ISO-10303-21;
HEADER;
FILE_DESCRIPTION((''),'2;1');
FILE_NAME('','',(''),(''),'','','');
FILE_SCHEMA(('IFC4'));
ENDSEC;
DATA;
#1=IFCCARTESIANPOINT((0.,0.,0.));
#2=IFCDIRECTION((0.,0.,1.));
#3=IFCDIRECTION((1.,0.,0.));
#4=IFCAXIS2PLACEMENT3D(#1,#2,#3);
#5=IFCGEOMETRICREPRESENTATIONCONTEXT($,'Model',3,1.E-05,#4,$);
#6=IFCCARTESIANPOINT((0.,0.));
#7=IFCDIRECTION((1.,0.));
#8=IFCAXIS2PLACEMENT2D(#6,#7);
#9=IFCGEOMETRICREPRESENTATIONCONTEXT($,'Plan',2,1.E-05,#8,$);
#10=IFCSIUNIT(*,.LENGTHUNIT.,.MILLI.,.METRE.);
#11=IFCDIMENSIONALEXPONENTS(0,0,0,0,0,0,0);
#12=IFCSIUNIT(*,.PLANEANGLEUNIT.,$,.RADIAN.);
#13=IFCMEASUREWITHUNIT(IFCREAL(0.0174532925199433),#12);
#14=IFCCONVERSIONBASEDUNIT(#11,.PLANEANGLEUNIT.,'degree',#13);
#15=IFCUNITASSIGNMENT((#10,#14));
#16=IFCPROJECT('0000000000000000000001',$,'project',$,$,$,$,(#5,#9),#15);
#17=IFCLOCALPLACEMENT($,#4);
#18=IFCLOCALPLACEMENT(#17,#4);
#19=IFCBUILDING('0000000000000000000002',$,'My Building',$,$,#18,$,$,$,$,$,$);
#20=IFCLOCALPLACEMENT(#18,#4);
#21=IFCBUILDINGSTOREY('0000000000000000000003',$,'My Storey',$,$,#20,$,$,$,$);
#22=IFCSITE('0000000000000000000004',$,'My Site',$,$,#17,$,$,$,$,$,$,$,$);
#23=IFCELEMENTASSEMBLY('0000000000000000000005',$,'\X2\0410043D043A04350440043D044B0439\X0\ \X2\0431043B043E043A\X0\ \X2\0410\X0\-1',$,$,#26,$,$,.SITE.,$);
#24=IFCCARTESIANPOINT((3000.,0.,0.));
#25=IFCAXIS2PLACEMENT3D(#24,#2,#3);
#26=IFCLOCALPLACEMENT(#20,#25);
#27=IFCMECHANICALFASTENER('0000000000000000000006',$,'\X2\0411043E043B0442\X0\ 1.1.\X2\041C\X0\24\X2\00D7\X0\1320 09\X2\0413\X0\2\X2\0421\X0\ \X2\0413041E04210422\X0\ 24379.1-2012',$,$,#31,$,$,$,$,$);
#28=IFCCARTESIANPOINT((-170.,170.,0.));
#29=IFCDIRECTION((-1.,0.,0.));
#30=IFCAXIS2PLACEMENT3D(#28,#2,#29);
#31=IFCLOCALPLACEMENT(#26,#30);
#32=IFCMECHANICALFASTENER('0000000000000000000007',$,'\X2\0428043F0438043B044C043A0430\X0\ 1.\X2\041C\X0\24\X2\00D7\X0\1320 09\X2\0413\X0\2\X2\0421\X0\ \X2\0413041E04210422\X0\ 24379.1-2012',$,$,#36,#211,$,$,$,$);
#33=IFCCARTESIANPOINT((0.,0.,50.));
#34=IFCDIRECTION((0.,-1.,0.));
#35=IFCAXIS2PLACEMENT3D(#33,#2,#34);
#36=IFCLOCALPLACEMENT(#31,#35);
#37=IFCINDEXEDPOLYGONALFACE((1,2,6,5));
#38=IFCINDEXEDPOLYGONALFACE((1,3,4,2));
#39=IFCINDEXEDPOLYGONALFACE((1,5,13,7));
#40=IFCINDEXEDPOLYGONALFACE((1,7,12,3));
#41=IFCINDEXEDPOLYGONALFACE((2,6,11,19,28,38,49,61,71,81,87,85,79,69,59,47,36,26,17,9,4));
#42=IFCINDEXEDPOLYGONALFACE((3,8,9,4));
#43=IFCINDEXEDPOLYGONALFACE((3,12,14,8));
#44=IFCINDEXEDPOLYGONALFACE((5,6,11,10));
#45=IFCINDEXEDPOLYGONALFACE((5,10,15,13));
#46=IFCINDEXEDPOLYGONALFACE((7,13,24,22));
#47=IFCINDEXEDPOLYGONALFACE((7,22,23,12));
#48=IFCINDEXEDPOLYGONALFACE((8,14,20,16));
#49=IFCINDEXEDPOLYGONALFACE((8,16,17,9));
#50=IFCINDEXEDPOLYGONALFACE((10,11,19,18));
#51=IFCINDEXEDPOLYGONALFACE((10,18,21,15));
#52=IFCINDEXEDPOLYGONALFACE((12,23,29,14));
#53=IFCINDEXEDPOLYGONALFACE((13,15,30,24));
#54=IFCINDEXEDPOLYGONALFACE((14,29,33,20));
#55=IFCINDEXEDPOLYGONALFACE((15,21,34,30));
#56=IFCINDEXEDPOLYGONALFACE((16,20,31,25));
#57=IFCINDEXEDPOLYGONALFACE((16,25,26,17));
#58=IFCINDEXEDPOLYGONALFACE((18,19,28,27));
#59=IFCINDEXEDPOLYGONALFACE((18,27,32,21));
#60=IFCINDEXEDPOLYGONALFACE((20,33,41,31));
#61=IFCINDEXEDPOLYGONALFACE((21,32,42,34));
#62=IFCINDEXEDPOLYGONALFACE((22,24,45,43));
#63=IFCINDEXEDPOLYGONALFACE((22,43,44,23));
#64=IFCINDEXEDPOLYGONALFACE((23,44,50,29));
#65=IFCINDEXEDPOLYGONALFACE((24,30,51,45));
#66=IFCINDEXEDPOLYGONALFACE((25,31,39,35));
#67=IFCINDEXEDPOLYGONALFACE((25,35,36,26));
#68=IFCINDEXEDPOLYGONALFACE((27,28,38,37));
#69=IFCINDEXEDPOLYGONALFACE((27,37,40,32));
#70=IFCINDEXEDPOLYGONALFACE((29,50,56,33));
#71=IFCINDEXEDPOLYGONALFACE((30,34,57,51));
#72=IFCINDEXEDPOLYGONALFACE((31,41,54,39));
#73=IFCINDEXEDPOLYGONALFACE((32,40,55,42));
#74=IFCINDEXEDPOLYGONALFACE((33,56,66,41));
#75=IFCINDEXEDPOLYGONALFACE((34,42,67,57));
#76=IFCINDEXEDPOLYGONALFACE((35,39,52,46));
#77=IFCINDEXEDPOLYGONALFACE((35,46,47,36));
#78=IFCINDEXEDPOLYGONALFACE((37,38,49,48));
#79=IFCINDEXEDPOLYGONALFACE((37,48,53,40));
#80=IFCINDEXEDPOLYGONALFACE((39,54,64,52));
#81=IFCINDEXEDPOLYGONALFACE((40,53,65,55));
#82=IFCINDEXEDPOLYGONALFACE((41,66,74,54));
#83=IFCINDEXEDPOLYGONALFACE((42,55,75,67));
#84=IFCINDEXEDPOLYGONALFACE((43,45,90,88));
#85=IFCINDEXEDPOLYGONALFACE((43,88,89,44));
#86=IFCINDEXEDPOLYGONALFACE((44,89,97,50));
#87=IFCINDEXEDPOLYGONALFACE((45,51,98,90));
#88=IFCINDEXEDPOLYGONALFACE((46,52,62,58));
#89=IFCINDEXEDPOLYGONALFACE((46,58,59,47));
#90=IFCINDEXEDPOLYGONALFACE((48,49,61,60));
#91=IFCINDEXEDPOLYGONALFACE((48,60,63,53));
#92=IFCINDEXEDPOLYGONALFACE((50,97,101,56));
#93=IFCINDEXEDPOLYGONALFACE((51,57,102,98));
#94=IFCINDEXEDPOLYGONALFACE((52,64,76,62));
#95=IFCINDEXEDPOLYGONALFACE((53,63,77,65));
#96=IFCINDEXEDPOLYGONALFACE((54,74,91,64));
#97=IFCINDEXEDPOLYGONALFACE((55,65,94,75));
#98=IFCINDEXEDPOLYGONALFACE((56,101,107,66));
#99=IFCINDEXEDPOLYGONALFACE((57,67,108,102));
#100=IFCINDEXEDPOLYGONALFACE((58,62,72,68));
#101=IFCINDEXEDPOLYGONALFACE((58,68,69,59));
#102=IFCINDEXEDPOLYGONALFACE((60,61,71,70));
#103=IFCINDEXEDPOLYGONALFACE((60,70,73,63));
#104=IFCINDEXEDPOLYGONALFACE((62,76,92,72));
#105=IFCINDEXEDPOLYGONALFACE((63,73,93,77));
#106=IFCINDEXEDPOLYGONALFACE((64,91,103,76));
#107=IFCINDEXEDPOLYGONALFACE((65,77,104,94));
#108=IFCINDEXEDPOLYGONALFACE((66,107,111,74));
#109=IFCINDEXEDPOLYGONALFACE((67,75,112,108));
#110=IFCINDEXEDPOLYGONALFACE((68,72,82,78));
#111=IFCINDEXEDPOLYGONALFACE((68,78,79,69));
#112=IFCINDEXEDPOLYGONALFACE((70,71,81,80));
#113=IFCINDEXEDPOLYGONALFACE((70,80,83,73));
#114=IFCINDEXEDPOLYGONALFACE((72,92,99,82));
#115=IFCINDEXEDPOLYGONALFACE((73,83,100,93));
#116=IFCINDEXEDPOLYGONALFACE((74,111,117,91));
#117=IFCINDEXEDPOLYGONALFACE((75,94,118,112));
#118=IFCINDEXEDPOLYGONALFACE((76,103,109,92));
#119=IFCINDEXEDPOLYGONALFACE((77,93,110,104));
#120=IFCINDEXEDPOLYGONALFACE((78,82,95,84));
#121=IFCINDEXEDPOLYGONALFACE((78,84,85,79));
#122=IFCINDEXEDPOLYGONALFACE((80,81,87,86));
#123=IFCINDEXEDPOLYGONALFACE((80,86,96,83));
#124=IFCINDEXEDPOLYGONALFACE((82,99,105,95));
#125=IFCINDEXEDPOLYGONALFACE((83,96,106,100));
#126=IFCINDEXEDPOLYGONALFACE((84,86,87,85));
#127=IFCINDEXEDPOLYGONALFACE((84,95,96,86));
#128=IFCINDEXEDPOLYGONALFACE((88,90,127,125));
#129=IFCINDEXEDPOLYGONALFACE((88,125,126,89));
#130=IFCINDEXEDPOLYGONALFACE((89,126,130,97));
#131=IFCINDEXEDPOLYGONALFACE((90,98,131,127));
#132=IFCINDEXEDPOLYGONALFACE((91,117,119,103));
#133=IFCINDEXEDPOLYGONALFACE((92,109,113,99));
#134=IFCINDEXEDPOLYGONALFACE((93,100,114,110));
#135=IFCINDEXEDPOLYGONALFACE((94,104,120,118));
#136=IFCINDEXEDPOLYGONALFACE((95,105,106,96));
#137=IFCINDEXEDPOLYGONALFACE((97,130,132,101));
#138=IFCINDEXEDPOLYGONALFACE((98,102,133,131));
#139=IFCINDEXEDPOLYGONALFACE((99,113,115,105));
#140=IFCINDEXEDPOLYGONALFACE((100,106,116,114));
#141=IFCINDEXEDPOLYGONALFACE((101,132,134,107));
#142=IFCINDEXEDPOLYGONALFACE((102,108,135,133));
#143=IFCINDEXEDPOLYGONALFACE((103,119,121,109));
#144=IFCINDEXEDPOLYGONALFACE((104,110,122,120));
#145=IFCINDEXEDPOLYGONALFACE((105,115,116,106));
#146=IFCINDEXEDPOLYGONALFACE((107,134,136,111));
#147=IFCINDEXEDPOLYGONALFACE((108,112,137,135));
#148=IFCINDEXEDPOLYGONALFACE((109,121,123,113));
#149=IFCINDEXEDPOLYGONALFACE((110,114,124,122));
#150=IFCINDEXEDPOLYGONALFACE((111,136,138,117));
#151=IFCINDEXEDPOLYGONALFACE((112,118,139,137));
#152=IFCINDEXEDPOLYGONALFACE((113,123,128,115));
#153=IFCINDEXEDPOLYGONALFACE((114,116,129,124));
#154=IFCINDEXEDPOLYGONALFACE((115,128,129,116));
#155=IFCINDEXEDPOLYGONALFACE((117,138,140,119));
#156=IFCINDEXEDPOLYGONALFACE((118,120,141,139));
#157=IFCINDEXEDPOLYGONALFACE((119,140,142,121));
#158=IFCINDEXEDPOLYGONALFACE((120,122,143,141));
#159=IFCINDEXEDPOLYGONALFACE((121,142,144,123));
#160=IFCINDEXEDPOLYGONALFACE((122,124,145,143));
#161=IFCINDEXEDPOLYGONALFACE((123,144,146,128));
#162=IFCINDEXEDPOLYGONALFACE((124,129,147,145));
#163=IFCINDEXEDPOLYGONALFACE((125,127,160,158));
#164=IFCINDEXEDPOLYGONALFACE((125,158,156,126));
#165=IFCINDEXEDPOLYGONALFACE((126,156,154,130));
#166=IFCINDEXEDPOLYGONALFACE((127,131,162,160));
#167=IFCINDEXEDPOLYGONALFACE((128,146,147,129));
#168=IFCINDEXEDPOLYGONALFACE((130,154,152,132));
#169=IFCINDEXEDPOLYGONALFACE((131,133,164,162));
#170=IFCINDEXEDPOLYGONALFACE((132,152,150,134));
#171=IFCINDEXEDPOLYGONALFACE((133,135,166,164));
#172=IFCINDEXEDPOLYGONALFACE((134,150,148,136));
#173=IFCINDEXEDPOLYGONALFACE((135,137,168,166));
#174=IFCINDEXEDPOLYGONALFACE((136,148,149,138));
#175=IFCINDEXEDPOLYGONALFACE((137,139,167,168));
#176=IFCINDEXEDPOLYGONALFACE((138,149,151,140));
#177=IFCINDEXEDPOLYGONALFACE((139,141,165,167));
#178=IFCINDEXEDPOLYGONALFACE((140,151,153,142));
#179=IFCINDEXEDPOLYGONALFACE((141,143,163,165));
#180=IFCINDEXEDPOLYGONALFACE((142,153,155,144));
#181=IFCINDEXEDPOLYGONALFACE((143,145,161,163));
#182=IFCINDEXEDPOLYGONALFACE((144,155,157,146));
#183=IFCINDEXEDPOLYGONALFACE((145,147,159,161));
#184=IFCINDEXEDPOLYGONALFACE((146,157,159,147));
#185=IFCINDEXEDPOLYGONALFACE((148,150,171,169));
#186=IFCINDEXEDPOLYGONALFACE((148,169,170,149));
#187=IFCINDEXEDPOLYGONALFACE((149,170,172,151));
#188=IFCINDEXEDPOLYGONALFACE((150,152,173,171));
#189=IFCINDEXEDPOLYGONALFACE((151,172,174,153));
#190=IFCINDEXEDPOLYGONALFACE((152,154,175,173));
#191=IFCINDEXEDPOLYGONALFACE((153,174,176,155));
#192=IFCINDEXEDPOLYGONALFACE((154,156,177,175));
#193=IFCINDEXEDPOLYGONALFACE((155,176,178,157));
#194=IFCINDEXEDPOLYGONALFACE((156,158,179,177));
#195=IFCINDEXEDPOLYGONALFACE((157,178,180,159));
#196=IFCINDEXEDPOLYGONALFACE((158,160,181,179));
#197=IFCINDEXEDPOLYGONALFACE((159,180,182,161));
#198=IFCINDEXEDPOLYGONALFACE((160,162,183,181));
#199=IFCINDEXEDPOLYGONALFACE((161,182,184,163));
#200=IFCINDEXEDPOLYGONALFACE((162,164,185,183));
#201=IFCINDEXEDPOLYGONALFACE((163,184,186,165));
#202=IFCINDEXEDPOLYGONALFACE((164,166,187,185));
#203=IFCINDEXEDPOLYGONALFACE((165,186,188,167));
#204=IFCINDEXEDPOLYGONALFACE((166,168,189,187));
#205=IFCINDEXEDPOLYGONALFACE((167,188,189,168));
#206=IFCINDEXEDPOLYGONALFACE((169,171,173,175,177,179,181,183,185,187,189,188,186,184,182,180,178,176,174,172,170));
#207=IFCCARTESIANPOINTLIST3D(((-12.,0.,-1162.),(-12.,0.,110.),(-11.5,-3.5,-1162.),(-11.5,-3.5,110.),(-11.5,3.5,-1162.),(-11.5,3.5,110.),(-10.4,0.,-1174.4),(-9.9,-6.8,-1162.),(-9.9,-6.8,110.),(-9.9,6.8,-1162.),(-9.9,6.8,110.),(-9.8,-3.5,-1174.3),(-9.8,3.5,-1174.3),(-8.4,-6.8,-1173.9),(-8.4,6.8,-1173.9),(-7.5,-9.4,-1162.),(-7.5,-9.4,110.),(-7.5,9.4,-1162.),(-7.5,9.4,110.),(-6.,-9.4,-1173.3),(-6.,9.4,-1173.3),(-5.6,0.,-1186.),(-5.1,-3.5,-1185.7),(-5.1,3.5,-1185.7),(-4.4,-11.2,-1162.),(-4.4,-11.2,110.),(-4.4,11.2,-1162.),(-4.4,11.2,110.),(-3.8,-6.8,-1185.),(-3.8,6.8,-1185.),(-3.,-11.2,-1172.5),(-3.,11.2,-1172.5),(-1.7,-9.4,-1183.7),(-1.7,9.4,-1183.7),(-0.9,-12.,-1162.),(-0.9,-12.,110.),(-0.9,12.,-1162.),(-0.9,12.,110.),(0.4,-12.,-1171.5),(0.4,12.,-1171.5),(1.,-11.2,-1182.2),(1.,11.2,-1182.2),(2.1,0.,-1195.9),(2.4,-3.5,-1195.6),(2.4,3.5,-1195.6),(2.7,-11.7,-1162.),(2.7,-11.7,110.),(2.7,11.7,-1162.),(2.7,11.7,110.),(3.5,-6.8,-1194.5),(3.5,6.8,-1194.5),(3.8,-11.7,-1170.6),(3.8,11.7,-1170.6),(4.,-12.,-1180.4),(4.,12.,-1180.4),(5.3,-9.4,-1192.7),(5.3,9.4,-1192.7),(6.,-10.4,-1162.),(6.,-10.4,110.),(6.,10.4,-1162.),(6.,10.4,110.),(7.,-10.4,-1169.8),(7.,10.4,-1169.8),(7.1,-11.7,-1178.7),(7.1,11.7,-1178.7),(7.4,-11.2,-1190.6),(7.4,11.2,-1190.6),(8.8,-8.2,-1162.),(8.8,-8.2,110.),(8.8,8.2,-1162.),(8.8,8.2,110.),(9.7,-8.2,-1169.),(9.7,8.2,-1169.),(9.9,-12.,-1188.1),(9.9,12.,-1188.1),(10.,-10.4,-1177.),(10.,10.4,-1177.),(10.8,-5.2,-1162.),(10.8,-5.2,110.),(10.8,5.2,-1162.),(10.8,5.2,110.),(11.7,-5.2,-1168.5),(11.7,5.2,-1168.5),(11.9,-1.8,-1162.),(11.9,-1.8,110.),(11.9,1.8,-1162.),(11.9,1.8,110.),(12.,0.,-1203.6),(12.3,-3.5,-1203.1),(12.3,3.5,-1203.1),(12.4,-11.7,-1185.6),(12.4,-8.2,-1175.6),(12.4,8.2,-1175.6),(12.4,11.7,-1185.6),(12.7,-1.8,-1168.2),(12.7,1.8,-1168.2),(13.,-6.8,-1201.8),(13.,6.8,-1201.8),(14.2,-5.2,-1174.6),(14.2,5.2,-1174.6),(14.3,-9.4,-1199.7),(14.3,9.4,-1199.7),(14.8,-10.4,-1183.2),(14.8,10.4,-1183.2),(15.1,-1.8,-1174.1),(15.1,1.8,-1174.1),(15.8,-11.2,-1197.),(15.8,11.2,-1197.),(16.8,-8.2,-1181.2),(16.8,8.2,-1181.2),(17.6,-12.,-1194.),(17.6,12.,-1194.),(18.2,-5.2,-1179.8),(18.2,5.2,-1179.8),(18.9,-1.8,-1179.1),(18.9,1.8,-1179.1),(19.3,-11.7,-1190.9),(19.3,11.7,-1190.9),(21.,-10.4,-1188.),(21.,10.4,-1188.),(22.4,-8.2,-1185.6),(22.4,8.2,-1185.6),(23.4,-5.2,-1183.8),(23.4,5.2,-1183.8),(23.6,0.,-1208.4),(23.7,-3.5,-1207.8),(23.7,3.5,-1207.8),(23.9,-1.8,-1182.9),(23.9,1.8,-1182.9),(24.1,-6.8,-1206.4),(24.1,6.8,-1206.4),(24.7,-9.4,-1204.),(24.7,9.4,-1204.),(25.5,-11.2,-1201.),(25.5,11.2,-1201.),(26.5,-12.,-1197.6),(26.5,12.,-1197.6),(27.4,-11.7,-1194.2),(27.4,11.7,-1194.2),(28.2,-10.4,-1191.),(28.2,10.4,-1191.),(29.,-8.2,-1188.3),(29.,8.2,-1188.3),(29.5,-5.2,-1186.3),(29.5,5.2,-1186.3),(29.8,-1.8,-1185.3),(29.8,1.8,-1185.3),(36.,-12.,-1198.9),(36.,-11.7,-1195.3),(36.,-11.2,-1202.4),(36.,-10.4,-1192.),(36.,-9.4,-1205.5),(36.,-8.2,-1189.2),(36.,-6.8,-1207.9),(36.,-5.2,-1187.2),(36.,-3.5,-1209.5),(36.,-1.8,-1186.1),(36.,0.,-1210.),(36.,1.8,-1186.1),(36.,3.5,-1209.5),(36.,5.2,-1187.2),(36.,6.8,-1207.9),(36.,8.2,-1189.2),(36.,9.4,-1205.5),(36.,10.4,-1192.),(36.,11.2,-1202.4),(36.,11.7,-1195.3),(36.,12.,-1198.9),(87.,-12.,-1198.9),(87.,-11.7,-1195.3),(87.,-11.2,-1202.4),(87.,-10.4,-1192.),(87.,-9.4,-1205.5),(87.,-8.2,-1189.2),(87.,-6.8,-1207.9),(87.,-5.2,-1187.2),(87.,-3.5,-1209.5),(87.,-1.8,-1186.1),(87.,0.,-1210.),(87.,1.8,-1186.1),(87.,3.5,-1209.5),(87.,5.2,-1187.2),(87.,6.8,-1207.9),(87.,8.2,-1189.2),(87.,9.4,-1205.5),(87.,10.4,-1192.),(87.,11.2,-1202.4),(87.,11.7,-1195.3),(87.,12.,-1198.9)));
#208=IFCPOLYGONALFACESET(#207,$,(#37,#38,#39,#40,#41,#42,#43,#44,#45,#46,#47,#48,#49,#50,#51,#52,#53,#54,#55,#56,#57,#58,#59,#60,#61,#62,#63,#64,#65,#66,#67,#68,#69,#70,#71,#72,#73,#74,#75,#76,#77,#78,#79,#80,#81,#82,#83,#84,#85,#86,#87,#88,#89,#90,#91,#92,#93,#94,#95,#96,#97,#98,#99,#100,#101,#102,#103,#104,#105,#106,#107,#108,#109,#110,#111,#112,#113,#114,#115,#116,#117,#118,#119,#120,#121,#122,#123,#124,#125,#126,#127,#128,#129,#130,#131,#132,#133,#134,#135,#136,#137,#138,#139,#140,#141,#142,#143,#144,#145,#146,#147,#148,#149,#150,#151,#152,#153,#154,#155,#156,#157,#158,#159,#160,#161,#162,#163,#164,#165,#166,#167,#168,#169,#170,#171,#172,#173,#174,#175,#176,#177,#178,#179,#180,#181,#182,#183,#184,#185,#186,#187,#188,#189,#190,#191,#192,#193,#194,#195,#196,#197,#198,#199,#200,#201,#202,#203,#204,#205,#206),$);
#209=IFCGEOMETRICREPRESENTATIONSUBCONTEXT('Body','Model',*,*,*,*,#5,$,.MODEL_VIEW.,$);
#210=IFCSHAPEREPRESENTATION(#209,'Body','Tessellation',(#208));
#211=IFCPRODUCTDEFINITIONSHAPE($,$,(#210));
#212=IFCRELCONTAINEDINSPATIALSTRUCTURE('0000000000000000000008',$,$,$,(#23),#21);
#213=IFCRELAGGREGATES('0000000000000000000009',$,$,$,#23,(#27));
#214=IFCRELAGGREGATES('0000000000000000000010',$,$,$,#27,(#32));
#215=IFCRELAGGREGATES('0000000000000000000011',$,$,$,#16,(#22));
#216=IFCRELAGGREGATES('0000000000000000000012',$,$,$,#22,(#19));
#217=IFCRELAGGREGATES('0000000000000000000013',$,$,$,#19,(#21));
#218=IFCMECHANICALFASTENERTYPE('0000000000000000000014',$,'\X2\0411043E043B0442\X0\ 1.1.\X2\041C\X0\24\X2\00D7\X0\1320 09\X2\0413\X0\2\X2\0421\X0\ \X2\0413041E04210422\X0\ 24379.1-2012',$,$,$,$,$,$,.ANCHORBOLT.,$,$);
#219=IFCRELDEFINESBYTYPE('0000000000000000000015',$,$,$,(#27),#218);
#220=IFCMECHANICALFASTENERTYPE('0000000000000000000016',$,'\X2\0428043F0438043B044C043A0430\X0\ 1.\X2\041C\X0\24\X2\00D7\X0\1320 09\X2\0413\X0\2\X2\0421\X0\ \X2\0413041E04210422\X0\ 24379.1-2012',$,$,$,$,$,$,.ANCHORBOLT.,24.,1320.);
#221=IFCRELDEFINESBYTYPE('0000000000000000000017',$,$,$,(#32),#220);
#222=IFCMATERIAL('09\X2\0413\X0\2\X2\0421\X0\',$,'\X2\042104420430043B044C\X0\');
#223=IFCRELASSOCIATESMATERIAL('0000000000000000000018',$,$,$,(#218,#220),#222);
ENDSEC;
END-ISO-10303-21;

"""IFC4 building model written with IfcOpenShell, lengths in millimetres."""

from ifc_helpers import new_model, entity, si_unit, converted_unit, frame, origin_with_axes, origin_2d_with_axis, place, context, subcontext, project, spatial, source, transform, mapped, material, type_object, type_shapes, element, aggregate, save


model = new_model("IFC4")

# Units and contexts
model_context = context("Model", 3, precision=1e-05, world=origin_with_axes())
plan_context = context("Plan", 2, precision=1e-05, world=origin_2d_with_axis())
body_context = subcontext(model_context, "Body", "Model", "MODEL_VIEW")
ifc_project = project(units=[si_unit("LENGTHUNIT", "METRE", prefix="MILLI"), converted_unit("PLANEANGLEUNIT", "degree", entity("IfcReal", 0.0174532925199433), si_unit("PLANEANGLEUNIT", "RADIAN"), dimensions=[0, 0, 0, 0, 0, 0, 0])], contexts=[model_context, plan_context])

# Site, building, storey
site_placement = place(None, origin_with_axes())
site = spatial("IfcSite", under=ifc_project, at=site_placement, Name="My Site")
building_placement = place(site_placement, origin_with_axes())
building = spatial("IfcBuilding", under=site, at=building_placement, Name="My Building")
storey_placement = place(building_placement, origin_with_axes())
storey = spatial("IfcBuildingStorey", under=building, at=storey_placement, Name="My Storey")

# Element assembly
placement_1 = place(storey_placement, frame((3000.0, 0.0, 0.0), z_axis=(0.0, 0.0, 1.0), x_axis=(1.0, 0.0, 0.0)))
assembly_1 = element("IfcElementAssembly", 1, at=placement_1, inside=storey, Name="Анкерный блок А-1", AssemblyPlace="SITE")

# Shared definitions
ifc_material_1 = material(Name="09Г2С", Category="Сталь")
mechanical_fastener_type_1 = type_object("IfcMechanicalFastenerType", Name="Болт 1.1.М24×1320 09Г2С ГОСТ 24379.1-2012", PredefinedType="ANCHORBOLT", material=ifc_material_1)
mechanical_fastener_type_2 = type_object("IfcMechanicalFastenerType", Name="Шпилька 1.М24×1320 09Г2С ГОСТ 24379.1-2012", NominalDiameter=24.0, NominalLength=1320.0, PredefinedType="ANCHORBOLT", material=ifc_material_1)
shared_shape_1 = source(frame((0.0, 0.0, 110.0), z_axis=(0.0, 0.0, 1.0), x_axis=(1.0, 0.0, 0.0)), body_context, "Body", "AdvancedSweptSolid", [
    entity("IfcSweptDiskSolid", entity("IfcIndexedPolyCurve", entity("IfcCartesianPointList3D", [[0.0, 0.0, 0.0], [0.0, 0.0, -1272.0], [10.5, 0.0, -1297.5], [36.0, 0.0, -1308.0], [87.0, 0.0, -1308.0]]), [entity("IfcLineIndex", [1, 2]), entity("IfcArcIndex", [2, 3, 4]), entity("IfcLineIndex", [4, 5])]), 12.0),
])
type_shapes(mechanical_fastener_type_2, [shared_shape_1])

# Mechanical fasteners
mechanical_fastener_1_placement = place(placement_1, frame((-170.0, 170.0, 0.0), z_axis=(0.0, 0.0, 1.0), x_axis=(-1.0, 0.0, 0.0)))
mechanical_fastener_1 = element("IfcMechanicalFastener", 2, at=mechanical_fastener_1_placement, type_object=mechanical_fastener_type_1, Name="Болт 1.1.М24×1320 09Г2С ГОСТ 24379.1-2012")
mechanical_fastener_2_placement = place(mechanical_fastener_1_placement, frame((0.0, 0.0, 50.0), z_axis=(0.0, 0.0, 1.0), x_axis=(0.0, -1.0, 0.0)))
mechanical_fastener_2 = element("IfcMechanicalFastener", 3, at=mechanical_fastener_2_placement, type_object=mechanical_fastener_type_2, Name="Шпилька 1.М24×1320 09Г2С ГОСТ 24379.1-2012", context=body_context, shape_type="MappedRepresentation", body=[
    mapped(shared_shape_1, transform((0.0, 0.0, 0.0), x_axis=(1.0, 0.0, 0.0), y_axis=(0.0, 1.0, 0.0), z_axis=(0.0, 0.0, 1.0), scale=1.0)),
])

aggregate(assembly_1, [mechanical_fastener_1])
aggregate(mechanical_fastener_1, [mechanical_fastener_2])

save(model, "model.ifc")
